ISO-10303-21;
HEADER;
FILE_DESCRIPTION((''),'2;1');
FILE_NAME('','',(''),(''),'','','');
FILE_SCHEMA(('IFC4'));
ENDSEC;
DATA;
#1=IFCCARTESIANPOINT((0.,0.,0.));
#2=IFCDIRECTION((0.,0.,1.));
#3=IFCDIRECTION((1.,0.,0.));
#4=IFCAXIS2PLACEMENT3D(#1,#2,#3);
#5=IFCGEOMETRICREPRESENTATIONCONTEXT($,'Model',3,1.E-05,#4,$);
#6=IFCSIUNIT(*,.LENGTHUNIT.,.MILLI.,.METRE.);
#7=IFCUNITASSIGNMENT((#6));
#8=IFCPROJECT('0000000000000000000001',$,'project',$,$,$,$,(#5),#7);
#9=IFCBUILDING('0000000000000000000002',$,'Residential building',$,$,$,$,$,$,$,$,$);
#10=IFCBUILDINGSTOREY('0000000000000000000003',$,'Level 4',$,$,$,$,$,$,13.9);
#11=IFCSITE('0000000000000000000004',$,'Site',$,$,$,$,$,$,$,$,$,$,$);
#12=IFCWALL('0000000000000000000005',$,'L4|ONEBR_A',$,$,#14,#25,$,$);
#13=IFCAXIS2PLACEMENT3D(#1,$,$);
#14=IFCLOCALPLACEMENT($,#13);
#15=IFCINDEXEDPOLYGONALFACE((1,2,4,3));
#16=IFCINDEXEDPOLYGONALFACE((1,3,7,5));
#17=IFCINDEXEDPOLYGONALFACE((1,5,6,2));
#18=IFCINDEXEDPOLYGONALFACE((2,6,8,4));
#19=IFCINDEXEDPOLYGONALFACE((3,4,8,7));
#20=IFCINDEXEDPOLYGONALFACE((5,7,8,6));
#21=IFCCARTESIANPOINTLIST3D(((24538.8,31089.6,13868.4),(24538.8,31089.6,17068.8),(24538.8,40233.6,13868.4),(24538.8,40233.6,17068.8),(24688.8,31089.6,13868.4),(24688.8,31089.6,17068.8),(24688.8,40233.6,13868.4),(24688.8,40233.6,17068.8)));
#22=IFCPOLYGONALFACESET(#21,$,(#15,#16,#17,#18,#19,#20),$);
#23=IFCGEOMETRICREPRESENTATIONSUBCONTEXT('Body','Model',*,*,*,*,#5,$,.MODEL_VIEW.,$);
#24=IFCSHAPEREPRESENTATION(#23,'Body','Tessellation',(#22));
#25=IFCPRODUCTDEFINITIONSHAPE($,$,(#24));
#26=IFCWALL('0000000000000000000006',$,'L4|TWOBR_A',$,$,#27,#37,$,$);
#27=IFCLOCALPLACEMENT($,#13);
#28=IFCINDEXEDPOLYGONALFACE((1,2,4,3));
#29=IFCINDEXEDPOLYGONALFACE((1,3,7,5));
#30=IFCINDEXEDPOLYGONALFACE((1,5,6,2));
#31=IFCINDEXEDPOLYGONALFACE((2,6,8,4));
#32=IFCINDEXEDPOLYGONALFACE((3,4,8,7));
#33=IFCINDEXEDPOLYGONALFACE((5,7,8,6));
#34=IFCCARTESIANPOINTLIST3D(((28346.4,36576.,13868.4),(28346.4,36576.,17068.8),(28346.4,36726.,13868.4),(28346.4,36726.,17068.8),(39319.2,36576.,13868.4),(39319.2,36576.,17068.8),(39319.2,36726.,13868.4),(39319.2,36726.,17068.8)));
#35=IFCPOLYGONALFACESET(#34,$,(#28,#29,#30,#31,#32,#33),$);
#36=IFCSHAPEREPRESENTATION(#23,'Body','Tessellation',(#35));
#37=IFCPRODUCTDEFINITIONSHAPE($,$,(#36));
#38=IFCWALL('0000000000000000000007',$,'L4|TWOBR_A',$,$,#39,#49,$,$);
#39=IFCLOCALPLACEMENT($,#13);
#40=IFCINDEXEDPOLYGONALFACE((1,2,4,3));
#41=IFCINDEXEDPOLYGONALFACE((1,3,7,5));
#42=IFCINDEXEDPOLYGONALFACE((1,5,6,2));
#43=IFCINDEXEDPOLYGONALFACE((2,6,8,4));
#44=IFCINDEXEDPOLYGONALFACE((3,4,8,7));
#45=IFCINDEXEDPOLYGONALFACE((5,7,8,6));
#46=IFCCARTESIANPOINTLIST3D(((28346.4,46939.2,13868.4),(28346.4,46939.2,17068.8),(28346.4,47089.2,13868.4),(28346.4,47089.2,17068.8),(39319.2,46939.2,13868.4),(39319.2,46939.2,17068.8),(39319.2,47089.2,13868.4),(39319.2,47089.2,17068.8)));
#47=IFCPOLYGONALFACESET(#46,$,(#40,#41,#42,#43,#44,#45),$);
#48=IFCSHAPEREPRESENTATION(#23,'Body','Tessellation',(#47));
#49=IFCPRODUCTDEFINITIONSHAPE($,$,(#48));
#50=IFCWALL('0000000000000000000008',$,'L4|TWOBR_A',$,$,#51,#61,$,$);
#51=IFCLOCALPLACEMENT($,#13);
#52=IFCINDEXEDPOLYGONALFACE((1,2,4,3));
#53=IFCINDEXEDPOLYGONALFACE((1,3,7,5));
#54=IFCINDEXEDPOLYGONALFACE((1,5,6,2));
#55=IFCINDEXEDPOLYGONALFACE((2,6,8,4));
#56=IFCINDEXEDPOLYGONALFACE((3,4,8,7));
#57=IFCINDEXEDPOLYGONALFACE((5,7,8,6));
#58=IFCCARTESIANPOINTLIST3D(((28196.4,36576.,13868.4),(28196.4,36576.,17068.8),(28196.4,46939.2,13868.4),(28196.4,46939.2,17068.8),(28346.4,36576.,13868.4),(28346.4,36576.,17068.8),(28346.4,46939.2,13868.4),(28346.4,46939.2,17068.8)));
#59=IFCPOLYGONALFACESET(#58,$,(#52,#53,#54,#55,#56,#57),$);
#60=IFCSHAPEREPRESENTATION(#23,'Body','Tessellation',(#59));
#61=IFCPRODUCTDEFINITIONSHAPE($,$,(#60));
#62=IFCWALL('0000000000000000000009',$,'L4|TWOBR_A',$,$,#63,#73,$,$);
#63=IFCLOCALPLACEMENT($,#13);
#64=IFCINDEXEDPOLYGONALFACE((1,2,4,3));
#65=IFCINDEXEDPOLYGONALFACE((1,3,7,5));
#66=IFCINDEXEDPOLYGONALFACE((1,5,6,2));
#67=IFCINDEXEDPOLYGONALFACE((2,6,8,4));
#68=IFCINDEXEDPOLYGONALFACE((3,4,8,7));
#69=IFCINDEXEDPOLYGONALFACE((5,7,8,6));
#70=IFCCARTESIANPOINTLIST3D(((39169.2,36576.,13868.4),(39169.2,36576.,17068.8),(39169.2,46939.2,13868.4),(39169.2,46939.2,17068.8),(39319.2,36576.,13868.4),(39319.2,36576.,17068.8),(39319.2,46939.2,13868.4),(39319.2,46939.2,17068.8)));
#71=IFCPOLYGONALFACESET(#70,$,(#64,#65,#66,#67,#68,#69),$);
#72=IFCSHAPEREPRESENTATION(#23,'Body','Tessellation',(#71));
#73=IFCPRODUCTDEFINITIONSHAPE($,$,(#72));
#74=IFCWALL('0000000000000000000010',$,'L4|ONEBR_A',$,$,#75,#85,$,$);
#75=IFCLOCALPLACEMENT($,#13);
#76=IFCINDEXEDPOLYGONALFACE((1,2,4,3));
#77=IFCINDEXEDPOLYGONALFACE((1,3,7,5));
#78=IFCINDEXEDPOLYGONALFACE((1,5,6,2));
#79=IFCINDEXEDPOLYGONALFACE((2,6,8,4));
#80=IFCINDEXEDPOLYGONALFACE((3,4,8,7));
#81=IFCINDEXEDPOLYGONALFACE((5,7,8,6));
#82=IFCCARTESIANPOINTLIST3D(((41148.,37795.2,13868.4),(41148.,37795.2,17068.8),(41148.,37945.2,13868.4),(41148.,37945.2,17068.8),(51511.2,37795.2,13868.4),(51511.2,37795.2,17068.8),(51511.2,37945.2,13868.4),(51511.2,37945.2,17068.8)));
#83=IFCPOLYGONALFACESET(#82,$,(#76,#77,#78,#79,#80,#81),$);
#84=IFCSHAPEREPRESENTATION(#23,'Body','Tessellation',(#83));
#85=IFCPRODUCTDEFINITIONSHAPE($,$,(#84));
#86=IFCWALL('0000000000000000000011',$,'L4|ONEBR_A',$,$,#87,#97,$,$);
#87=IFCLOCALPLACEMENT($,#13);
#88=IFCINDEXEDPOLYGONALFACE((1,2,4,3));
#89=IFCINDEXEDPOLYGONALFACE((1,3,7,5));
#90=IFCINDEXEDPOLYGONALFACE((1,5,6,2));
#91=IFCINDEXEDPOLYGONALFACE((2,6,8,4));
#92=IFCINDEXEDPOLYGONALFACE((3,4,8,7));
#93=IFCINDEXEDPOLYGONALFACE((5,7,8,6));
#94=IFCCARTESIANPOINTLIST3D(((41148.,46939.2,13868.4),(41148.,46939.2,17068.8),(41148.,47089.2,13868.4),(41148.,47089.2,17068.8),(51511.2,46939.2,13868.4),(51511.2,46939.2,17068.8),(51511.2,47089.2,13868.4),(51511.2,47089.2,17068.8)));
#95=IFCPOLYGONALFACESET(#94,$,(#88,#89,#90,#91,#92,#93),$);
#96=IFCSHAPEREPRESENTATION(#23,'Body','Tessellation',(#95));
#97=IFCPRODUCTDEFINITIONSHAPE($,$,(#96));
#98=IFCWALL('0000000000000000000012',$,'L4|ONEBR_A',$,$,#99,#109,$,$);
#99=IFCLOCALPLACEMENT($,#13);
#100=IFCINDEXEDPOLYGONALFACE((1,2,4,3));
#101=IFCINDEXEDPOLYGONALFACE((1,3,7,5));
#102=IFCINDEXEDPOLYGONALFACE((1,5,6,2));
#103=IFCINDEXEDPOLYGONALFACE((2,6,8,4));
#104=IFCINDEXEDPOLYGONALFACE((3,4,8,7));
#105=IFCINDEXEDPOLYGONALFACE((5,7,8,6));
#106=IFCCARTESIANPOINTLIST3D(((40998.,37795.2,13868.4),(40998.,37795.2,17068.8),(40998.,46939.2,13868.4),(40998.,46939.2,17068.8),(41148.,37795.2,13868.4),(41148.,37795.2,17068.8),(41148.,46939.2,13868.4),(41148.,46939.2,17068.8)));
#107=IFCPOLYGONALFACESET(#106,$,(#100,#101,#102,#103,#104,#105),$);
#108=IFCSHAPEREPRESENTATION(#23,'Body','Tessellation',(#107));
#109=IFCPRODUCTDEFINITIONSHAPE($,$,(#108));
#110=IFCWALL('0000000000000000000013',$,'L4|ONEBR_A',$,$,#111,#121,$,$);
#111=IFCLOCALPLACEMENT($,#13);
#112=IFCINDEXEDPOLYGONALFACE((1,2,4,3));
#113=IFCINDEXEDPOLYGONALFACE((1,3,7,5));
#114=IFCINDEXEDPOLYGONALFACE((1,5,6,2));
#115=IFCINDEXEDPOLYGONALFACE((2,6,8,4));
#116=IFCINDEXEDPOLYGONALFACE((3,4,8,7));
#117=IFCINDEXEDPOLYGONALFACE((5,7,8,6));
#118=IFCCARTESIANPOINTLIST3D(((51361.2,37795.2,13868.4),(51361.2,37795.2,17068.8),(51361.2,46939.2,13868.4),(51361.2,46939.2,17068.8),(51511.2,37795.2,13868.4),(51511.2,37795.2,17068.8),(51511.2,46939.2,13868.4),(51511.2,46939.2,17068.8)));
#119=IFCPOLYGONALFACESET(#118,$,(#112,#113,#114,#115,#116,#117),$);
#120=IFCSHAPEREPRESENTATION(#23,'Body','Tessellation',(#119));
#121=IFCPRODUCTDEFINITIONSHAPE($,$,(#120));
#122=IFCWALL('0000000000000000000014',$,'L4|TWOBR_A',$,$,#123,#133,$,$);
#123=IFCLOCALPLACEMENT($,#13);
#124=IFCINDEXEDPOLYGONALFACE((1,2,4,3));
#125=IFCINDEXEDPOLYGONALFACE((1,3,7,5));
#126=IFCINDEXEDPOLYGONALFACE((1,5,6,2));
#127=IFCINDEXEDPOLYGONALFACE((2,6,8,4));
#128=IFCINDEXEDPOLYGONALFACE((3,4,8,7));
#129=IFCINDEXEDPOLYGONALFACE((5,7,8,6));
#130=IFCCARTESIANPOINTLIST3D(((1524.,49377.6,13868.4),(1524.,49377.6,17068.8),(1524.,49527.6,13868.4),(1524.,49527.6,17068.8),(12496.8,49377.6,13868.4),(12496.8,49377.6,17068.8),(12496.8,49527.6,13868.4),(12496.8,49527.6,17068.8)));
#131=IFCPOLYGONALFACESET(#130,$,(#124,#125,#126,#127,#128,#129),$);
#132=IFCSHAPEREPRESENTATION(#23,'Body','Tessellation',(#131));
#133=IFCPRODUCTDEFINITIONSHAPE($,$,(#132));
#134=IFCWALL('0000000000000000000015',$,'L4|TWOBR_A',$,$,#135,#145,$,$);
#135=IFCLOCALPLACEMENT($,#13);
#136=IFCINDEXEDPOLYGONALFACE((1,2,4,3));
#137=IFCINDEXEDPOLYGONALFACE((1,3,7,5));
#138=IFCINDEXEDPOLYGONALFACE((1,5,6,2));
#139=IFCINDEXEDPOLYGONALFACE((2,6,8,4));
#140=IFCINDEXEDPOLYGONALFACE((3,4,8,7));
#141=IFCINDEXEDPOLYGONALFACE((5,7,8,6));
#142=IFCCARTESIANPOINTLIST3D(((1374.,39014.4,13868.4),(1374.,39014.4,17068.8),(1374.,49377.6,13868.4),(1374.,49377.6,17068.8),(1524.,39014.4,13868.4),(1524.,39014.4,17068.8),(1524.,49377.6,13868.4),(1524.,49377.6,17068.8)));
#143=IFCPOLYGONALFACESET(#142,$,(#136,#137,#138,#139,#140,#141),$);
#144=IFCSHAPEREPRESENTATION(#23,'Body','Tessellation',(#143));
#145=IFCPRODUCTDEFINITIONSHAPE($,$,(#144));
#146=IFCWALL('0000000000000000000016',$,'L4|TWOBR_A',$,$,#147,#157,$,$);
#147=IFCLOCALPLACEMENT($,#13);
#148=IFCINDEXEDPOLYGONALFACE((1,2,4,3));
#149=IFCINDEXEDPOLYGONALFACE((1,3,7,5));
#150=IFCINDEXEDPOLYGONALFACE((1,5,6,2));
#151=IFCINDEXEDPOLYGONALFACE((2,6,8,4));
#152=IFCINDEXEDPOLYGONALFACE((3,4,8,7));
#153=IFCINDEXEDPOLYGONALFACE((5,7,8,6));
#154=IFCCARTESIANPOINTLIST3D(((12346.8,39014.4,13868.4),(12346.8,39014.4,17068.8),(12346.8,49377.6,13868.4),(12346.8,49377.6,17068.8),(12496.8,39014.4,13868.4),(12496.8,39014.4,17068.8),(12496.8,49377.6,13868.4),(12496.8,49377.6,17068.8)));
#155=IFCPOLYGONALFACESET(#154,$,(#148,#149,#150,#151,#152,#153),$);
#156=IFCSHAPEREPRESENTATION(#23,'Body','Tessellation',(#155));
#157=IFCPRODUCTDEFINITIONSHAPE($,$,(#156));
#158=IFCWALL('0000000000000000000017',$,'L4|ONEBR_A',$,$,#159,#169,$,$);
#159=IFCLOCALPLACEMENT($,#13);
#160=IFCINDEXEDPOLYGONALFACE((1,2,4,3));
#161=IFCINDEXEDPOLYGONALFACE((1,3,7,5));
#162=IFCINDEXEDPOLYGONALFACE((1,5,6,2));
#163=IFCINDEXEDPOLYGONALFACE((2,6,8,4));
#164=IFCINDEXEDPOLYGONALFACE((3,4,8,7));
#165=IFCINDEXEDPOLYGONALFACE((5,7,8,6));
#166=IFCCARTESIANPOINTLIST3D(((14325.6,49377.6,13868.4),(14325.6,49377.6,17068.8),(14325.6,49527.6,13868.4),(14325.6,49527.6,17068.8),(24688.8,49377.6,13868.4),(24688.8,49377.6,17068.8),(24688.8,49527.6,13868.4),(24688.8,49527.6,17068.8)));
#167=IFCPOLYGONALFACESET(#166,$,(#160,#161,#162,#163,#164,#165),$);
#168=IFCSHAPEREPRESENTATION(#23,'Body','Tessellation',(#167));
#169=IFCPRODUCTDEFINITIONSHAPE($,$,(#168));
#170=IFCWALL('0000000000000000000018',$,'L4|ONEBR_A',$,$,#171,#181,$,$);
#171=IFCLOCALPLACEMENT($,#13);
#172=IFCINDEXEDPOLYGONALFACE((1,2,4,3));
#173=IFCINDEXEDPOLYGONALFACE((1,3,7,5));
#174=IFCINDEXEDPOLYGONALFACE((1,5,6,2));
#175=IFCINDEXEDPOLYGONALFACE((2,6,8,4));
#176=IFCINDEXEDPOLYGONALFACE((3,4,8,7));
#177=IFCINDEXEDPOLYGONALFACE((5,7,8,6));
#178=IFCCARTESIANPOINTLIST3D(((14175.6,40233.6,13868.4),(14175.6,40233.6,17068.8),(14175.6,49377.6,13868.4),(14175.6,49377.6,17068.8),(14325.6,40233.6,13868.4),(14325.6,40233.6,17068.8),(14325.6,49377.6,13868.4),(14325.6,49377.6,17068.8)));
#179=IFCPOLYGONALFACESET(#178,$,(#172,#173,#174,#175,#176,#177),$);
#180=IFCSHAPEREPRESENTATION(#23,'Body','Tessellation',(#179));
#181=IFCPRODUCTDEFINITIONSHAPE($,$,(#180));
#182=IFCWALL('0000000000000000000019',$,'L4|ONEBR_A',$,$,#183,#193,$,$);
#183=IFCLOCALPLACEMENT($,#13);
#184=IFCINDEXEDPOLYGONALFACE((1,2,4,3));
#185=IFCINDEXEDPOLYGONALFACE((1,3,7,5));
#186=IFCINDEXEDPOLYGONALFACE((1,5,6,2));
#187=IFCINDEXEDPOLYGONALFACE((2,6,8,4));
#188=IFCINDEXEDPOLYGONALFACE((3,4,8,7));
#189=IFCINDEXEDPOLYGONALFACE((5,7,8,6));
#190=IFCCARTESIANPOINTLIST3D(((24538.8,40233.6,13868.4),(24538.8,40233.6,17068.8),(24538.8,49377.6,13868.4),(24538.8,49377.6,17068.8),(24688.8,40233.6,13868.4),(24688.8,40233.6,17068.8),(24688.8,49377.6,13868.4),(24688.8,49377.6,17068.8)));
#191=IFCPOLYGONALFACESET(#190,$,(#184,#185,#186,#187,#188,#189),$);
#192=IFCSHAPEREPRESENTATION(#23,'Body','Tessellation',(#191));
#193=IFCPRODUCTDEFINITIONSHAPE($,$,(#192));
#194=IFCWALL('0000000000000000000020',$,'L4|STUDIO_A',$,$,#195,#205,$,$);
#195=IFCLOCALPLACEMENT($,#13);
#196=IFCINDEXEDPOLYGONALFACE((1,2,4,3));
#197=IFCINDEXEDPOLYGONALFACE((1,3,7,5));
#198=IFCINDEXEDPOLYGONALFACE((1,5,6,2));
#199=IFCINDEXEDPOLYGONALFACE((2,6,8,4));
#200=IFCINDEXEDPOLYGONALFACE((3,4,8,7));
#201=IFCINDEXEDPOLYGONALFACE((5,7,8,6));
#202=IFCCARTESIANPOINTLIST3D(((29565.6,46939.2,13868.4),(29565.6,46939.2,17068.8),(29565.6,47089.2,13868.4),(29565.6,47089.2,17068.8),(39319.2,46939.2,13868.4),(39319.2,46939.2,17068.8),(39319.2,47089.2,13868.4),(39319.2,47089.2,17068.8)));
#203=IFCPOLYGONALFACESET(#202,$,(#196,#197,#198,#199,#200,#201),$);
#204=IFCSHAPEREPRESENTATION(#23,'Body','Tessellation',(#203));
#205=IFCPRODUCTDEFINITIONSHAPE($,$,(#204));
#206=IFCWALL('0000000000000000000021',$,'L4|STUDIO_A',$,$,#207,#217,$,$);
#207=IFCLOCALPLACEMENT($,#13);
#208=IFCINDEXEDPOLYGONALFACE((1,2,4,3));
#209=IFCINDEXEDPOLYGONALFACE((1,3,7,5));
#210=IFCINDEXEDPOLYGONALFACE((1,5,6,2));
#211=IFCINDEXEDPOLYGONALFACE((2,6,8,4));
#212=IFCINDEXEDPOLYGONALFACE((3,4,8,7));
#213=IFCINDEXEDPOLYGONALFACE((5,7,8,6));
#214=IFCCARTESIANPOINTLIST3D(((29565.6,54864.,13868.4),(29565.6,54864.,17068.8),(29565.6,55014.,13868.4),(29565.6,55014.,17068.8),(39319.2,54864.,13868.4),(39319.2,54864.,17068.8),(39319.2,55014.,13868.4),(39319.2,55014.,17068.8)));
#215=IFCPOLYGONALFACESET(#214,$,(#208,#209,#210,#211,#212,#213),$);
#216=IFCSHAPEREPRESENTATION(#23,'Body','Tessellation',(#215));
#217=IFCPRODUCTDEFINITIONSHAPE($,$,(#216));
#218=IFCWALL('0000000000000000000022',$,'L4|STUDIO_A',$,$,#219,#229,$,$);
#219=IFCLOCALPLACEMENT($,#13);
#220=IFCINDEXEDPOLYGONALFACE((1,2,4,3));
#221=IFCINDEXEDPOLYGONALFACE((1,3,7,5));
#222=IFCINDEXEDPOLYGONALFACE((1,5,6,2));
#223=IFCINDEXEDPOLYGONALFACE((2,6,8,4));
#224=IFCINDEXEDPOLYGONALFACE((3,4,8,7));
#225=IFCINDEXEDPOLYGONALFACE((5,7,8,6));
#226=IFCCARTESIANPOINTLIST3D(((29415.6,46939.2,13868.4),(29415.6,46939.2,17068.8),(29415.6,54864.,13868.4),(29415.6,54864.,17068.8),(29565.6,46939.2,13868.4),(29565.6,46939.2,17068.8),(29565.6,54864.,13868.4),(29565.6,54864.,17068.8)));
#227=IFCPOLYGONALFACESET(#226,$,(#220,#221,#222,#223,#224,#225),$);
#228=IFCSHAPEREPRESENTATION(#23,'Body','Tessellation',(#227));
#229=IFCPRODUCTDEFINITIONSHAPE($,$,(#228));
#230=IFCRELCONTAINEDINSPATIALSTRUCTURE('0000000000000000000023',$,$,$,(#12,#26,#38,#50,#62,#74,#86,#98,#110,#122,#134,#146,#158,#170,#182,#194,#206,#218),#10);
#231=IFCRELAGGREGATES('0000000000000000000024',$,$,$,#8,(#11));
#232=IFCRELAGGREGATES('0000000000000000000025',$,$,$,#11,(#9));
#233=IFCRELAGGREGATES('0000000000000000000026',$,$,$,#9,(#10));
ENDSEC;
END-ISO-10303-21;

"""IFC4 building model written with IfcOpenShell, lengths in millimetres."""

from ifc_helpers import new_model, si_unit, frame, origin_with_axes, place, context, subcontext, project, spatial, indexed_curve, outline, extrude, element, save


model = new_model("IFC4")

# Units and contexts
model_context = context("Model", 3, precision=1e-05, world=origin_with_axes())
body_context = subcontext(model_context, "Body", "Model", "MODEL_VIEW")
ifc_project = project(units=[si_unit("LENGTHUNIT", "METRE", prefix="MILLI")], contexts=[model_context])

# Site, building, storey
site = spatial("IfcSite", under=ifc_project, Name="Site")
building = spatial("IfcBuilding", under=site, Name="Residential building")
storey = spatial("IfcBuildingStorey", under=building, Name="Level 4", Elevation=13.9)

# Walls
for number, where, z_axis, x_axis, name in (
    (1, (24688.8, 31089.6, 13868.4), (0.0, 0.0, 1.0), (0.0, 1.0, 0.0), "L4|ONEBR_A"),
):
    element("IfcWall", number, at=place(None, frame(where, z_axis=z_axis, x_axis=x_axis)), inside=storey, Name=name, context=body_context, shape_type="SweptSolid", body=[
        extrude(outline(indexed_curve([(0.0, 0.0), (0.0, 150.0), (9144.0, 150.0), (9144.0, 0.0), (0.0, 0.0)], self_intersect=False)), origin_with_axes(), (0.0, 0.0, 1.0), 3200.4),
    ])
for number, where, z_axis, x_axis, name in (
    (2, (28346.4, 36576.0, 13868.4), (0.0, 0.0, 1.0), (1.0, 0.0, 0.0), "L4|TWOBR_A"),
    (3, (28346.4, 46939.2, 13868.4), (0.0, 0.0, 1.0), (1.0, 0.0, 0.0), "L4|TWOBR_A"),
):
    element("IfcWall", number, at=place(None, frame(where, z_axis=z_axis, x_axis=x_axis)), inside=storey, Name=name, context=body_context, shape_type="SweptSolid", body=[
        extrude(outline(indexed_curve([(0.0, 0.0), (0.0, 150.0), (10972.8, 150.0), (10972.8, 0.0), (0.0, 0.0)], self_intersect=False)), origin_with_axes(), (0.0, 0.0, 1.0), 3200.4),
    ])
for number, where, z_axis, x_axis, name in (
    (4, (28346.4, 36576.0, 13868.4), (0.0, 0.0, 1.0), (0.0, 1.0, 0.0), "L4|TWOBR_A"),
    (5, (39319.2, 36576.0, 13868.4), (0.0, 0.0, 1.0), (0.0, 1.0, 0.0), "L4|TWOBR_A"),
    (6, (41148.0, 37795.2, 13868.4), (0.0, 0.0, 1.0), (1.0, 0.0, 0.0), "L4|ONEBR_A"),
    (7, (41148.0, 46939.2, 13868.4), (0.0, 0.0, 1.0), (1.0, 0.0, 0.0), "L4|ONEBR_A"),
):
    element("IfcWall", number, at=place(None, frame(where, z_axis=z_axis, x_axis=x_axis)), inside=storey, Name=name, context=body_context, shape_type="SweptSolid", body=[
        extrude(outline(indexed_curve([(0.0, 0.0), (0.0, 150.0), (10363.2, 150.0), (10363.2, 0.0), (0.0, 0.0)], self_intersect=False)), origin_with_axes(), (0.0, 0.0, 1.0), 3200.4),
    ])
for number, where, z_axis, x_axis, name in (
    (8, (41148.0, 37795.2, 13868.4), (0.0, 0.0, 1.0), (0.0, 1.0, 0.0), "L4|ONEBR_A"),
    (9, (51511.2, 37795.2, 13868.4), (0.0, 0.0, 1.0), (0.0, 1.0, 0.0), "L4|ONEBR_A"),
):
    element("IfcWall", number, at=place(None, frame(where, z_axis=z_axis, x_axis=x_axis)), inside=storey, Name=name, context=body_context, shape_type="SweptSolid", body=[
        extrude(outline(indexed_curve([(0.0, 0.0), (0.0, 150.0), (9144.0, 150.0), (9144.0, 0.0), (0.0, 0.0)], self_intersect=False)), origin_with_axes(), (0.0, 0.0, 1.0), 3200.4),
    ])
for number, where, z_axis, x_axis, name in (
    (10, (1524.0, 49377.6, 13868.4), (0.0, 0.0, 1.0), (1.0, 0.0, 0.0), "L4|TWOBR_A"),
):
    element("IfcWall", number, at=place(None, frame(where, z_axis=z_axis, x_axis=x_axis)), inside=storey, Name=name, context=body_context, shape_type="SweptSolid", body=[
        extrude(outline(indexed_curve([(0.0, 0.0), (0.0, 150.0), (10972.8, 150.0), (10972.8, 0.0), (0.0, 0.0)], self_intersect=False)), origin_with_axes(), (0.0, 0.0, 1.0), 3200.4),
    ])
for number, where, z_axis, x_axis, name in (
    (11, (1524.0, 39014.4, 13868.4), (0.0, 0.0, 1.0), (0.0, 1.0, 0.0), "L4|TWOBR_A"),
    (12, (12496.8, 39014.4, 13868.4), (0.0, 0.0, 1.0), (0.0, 1.0, 0.0), "L4|TWOBR_A"),
    (13, (14325.6, 49377.6, 13868.4), (0.0, 0.0, 1.0), (1.0, 0.0, 0.0), "L4|ONEBR_A"),
):
    element("IfcWall", number, at=place(None, frame(where, z_axis=z_axis, x_axis=x_axis)), inside=storey, Name=name, context=body_context, shape_type="SweptSolid", body=[
        extrude(outline(indexed_curve([(0.0, 0.0), (0.0, 150.0), (10363.2, 150.0), (10363.2, 0.0), (0.0, 0.0)], self_intersect=False)), origin_with_axes(), (0.0, 0.0, 1.0), 3200.4),
    ])
for number, where, z_axis, x_axis, name in (
    (14, (14325.6, 40233.6, 13868.4), (0.0, 0.0, 1.0), (0.0, 1.0, 0.0), "L4|ONEBR_A"),
    (15, (24688.8, 40233.6, 13868.4), (0.0, 0.0, 1.0), (0.0, 1.0, 0.0), "L4|ONEBR_A"),
):
    element("IfcWall", number, at=place(None, frame(where, z_axis=z_axis, x_axis=x_axis)), inside=storey, Name=name, context=body_context, shape_type="SweptSolid", body=[
        extrude(outline(indexed_curve([(0.0, 0.0), (0.0, 150.0), (9144.0, 150.0), (9144.0, 0.0), (0.0, 0.0)], self_intersect=False)), origin_with_axes(), (0.0, 0.0, 1.0), 3200.4),
    ])
for number, where, z_axis, x_axis, name in (
    (16, (29565.6, 46939.2, 13868.4), (0.0, 0.0, 1.0), (1.0, 0.0, 0.0), "L4|STUDIO_A"),
    (17, (29565.6, 54864.0, 13868.4), (0.0, 0.0, 1.0), (1.0, 0.0, 0.0), "L4|STUDIO_A"),
):
    element("IfcWall", number, at=place(None, frame(where, z_axis=z_axis, x_axis=x_axis)), inside=storey, Name=name, context=body_context, shape_type="SweptSolid", body=[
        extrude(outline(indexed_curve([(0.0, 0.0), (0.0, 150.0), (9753.6, 150.0), (9753.6, 0.0), (0.0, 0.0)], self_intersect=False)), origin_with_axes(), (0.0, 0.0, 1.0), 3200.4),
    ])
for number, where, z_axis, x_axis, name in (
    (18, (29565.6, 46939.2, 13868.4), (0.0, 0.0, 1.0), (0.0, 1.0, 0.0), "L4|STUDIO_A"),
):
    element("IfcWall", number, at=place(None, frame(where, z_axis=z_axis, x_axis=x_axis)), inside=storey, Name=name, context=body_context, shape_type="SweptSolid", body=[
        extrude(outline(indexed_curve([(0.0, 0.0), (0.0, 150.0), (7924.8, 150.0), (7924.8, 0.0), (0.0, 0.0)], self_intersect=False)), origin_with_axes(), (0.0, 0.0, 1.0), 3200.4),
    ])

save(model, "model.ifc")
